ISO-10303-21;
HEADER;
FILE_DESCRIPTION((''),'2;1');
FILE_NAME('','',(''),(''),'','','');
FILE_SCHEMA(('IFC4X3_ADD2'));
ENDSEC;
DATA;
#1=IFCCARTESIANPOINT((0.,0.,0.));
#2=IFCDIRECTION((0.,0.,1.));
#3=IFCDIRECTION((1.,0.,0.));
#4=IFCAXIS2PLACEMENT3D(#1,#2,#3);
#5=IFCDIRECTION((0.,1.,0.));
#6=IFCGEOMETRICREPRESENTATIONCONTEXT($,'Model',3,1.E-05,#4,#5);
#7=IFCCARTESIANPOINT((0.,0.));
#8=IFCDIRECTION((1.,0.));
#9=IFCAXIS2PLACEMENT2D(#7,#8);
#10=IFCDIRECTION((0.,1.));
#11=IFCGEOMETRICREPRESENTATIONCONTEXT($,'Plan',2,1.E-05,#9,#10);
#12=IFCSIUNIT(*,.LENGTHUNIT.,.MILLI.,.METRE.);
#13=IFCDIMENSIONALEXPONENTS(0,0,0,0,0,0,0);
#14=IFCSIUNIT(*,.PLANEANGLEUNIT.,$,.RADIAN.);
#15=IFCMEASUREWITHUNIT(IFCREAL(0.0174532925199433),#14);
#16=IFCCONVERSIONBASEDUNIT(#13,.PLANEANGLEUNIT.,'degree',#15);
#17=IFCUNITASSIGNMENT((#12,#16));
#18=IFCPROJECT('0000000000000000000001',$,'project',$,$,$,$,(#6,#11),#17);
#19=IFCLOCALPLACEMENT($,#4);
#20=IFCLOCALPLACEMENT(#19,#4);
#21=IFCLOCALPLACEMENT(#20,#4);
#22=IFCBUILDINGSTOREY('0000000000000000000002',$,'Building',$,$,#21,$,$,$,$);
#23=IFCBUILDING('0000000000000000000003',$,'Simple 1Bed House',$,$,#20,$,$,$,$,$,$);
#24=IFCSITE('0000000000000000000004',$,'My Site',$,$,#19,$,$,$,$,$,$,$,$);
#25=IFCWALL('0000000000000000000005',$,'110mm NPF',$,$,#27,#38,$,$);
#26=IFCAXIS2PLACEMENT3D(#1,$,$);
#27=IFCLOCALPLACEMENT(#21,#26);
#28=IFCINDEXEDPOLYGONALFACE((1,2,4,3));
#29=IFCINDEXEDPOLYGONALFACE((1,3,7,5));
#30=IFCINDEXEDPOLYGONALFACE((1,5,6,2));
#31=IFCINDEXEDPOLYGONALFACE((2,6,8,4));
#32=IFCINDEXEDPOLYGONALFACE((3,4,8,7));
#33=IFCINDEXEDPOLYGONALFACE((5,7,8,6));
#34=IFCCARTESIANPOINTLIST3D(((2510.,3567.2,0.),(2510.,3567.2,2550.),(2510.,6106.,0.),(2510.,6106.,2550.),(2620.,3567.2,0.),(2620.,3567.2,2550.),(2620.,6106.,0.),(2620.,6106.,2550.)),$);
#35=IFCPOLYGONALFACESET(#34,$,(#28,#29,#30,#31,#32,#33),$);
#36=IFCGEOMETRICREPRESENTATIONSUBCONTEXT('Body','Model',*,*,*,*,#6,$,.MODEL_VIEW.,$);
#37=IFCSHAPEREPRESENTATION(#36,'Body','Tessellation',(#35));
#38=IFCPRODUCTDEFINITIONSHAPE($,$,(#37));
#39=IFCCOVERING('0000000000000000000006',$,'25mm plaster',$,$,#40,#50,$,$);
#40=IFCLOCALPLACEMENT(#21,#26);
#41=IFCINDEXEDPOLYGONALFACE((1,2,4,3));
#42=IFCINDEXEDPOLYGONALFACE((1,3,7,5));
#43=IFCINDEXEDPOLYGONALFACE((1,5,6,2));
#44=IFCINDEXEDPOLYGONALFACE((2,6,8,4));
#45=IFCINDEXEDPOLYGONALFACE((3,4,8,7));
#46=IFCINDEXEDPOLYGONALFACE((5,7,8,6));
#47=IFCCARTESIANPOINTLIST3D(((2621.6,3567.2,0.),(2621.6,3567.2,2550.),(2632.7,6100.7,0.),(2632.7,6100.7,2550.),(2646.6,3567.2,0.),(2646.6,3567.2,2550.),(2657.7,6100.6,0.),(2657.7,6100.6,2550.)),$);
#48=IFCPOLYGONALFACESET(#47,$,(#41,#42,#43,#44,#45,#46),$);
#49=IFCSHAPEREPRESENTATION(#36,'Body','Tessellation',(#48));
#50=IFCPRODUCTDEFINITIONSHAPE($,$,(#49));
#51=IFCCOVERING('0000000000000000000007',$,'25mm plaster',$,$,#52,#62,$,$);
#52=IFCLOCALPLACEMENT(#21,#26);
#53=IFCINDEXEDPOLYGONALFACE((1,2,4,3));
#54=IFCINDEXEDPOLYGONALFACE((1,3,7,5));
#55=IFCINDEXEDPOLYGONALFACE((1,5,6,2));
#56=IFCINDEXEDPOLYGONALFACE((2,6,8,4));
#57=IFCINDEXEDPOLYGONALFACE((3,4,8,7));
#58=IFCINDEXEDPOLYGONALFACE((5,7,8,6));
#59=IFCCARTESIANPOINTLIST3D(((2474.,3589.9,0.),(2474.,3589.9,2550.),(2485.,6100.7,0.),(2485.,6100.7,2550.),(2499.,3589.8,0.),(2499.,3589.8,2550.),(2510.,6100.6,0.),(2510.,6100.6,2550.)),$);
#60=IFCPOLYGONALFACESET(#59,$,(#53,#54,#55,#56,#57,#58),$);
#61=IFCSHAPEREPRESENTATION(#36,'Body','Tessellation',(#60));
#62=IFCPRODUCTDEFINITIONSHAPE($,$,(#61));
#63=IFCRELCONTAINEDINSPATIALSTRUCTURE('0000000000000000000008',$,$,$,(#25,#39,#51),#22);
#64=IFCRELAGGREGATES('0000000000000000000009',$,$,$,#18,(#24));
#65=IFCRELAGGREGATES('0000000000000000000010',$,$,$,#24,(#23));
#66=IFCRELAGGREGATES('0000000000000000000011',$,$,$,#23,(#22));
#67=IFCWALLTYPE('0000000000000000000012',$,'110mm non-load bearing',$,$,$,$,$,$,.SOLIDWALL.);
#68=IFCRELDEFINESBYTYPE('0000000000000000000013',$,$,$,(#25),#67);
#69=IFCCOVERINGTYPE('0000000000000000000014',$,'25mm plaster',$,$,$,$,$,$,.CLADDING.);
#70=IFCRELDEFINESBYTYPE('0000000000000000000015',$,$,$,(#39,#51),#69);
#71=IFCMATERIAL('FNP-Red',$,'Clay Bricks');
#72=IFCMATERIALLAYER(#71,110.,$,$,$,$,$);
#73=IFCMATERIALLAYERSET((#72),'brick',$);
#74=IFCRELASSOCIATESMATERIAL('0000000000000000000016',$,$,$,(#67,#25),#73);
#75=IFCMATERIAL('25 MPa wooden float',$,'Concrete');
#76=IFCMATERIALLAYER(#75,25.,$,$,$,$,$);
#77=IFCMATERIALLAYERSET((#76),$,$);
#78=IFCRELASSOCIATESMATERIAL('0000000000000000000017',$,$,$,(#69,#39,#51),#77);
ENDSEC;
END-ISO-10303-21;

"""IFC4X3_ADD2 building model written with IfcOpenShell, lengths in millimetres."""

from ifc_helpers import new_model, entity, si_unit, converted_unit, direction, frame, origin_with_axes, origin_2d_with_axis, place, context, subcontext, project, spatial, indexed_curve, outline, extrude, clip, halfspace, material, layer, layer_set, layer_usage, type_object, element, save


model = new_model("IFC4X3_ADD2")

# Units and contexts
model_context = context("Model", 3, precision=1e-05, world=origin_with_axes(), true_north=direction((0.0, 1.0, 0.0)))
plan_context = context("Plan", 2, precision=1e-05, world=origin_2d_with_axis(), true_north=direction((0.0, 1.0)))
body_context = subcontext(model_context, "Body", "Model", "MODEL_VIEW")
ifc_project = project(units=[si_unit("LENGTHUNIT", "METRE", prefix="MILLI"), converted_unit("PLANEANGLEUNIT", "degree", entity("IfcReal", 0.0174532925199433), si_unit("PLANEANGLEUNIT", "RADIAN"), dimensions=[0, 0, 0, 0, 0, 0, 0])], contexts=[model_context, plan_context])

# Site, building, storey
site_placement = place(None, origin_with_axes())
site = spatial("IfcSite", under=ifc_project, at=site_placement, Name="My Site")
building_placement = place(site_placement, origin_with_axes())
building = spatial("IfcBuilding", under=site, at=building_placement, Name="Simple 1Bed House")
storey_placement = place(building_placement, origin_with_axes())
storey = spatial("IfcBuildingStorey", under=building, at=storey_placement, Name="Building")

# Wall
ifc_material_1 = material(Name="FNP-Red", Category="Clay Bricks")
ifc_layer_1 = layer(ifc_material_1, 110.0)
ifc_layer_set_1 = layer_set([ifc_layer_1], Name="brick")
ifc_layer_usage_1 = layer_usage(ifc_layer_set_1, "AXIS2", "POSITIVE", 0.0)
wall_type = type_object("IfcWallType", Name="110mm non-load bearing", PredefinedType="SOLIDWALL", material=ifc_layer_set_1)
wall_placement = place(storey_placement, frame((2620.0, 3567.2, 0.0), z_axis=(0.0, 0.0, 1.0), x_axis=(-0.000001, 1.0, 0.0)))
element("IfcWall", 1, at=wall_placement, inside=storey, type_object=wall_type, material=ifc_layer_usage_1, Name="110mm NPF", context=body_context, shape_type="SweptSolid", body=[
    extrude(outline(indexed_curve([(0.0, 0.0), (0.0, 110.0), (2538.8, 110.0), (2538.8, 0.0), (0.0, 0.0)], self_intersect=False)), origin_with_axes(), (0.0, 0.0, 1.0), 2550.0),
])

# Coverings
ifc_material_2 = material(Name="25 MPa wooden float", Category="Concrete")
ifc_layer_2 = layer(ifc_material_2, 25.0)
ifc_layer_set_2 = layer_set([ifc_layer_2])
ifc_layer_usage_2 = layer_usage(ifc_layer_set_2, "AXIS2", "POSITIVE", 0.0)
covering_type = type_object("IfcCoveringType", Name="25mm plaster", PredefinedType="CLADDING", material=ifc_layer_set_2)
covering_1_placement = place(storey_placement, frame((2632.7, 6100.7, 0.0), z_axis=(0.0, 0.0, 1.0), x_axis=(-0.004378, -0.99999, 0.0)))
element("IfcCovering", 2, at=covering_1_placement, inside=storey, type_object=covering_type, material=ifc_layer_usage_2, Name="25mm plaster", context=body_context, shape_type="Clipping", body=[
    clip(extrude(outline(indexed_curve([(0.0, 0.0), (0.0, 25.0), (2643.5, 25.0), (2643.5, 0.0), (0.0, 0.0)], self_intersect=False)), origin_with_axes(), (0.0, 0.0, 1.0), 2550.0), halfspace(frame((2533.5, 0.0, 0.0), z_axis=(0.06375, 0.000279, 0.0), x_axis=(0.004378, -0.99999, 0.0)), False)),
])
ifc_layer_usage_3 = layer_usage(ifc_layer_set_2, "AXIS2", "POSITIVE", 0.0)
covering_2_placement = place(storey_placement, frame((2485.0, 6100.7, 0.0), z_axis=(0.0, 0.0, 1.0), x_axis=(-0.004378, -0.99999, 0.0)))
element("IfcCovering", 3, at=covering_2_placement, inside=storey, type_object=covering_type, material=ifc_layer_usage_3, Name="25mm plaster", context=body_context, shape_type="Clipping", body=[
    clip(extrude(outline(indexed_curve([(0.0, 0.0), (0.0, 25.0), (2535.9, 25.0), (2535.9, 0.0), (0.0, 0.0)], self_intersect=False)), origin_with_axes(), (0.0, 0.0, 1.0), 2550.0), halfspace(frame((2510.9, 0.0, 0.0), z_axis=(0.063751, 0.000187, 0.0), x_axis=(0.002929, -0.999996, 0.0)), False)),
])

save(model, "model.ifc")
